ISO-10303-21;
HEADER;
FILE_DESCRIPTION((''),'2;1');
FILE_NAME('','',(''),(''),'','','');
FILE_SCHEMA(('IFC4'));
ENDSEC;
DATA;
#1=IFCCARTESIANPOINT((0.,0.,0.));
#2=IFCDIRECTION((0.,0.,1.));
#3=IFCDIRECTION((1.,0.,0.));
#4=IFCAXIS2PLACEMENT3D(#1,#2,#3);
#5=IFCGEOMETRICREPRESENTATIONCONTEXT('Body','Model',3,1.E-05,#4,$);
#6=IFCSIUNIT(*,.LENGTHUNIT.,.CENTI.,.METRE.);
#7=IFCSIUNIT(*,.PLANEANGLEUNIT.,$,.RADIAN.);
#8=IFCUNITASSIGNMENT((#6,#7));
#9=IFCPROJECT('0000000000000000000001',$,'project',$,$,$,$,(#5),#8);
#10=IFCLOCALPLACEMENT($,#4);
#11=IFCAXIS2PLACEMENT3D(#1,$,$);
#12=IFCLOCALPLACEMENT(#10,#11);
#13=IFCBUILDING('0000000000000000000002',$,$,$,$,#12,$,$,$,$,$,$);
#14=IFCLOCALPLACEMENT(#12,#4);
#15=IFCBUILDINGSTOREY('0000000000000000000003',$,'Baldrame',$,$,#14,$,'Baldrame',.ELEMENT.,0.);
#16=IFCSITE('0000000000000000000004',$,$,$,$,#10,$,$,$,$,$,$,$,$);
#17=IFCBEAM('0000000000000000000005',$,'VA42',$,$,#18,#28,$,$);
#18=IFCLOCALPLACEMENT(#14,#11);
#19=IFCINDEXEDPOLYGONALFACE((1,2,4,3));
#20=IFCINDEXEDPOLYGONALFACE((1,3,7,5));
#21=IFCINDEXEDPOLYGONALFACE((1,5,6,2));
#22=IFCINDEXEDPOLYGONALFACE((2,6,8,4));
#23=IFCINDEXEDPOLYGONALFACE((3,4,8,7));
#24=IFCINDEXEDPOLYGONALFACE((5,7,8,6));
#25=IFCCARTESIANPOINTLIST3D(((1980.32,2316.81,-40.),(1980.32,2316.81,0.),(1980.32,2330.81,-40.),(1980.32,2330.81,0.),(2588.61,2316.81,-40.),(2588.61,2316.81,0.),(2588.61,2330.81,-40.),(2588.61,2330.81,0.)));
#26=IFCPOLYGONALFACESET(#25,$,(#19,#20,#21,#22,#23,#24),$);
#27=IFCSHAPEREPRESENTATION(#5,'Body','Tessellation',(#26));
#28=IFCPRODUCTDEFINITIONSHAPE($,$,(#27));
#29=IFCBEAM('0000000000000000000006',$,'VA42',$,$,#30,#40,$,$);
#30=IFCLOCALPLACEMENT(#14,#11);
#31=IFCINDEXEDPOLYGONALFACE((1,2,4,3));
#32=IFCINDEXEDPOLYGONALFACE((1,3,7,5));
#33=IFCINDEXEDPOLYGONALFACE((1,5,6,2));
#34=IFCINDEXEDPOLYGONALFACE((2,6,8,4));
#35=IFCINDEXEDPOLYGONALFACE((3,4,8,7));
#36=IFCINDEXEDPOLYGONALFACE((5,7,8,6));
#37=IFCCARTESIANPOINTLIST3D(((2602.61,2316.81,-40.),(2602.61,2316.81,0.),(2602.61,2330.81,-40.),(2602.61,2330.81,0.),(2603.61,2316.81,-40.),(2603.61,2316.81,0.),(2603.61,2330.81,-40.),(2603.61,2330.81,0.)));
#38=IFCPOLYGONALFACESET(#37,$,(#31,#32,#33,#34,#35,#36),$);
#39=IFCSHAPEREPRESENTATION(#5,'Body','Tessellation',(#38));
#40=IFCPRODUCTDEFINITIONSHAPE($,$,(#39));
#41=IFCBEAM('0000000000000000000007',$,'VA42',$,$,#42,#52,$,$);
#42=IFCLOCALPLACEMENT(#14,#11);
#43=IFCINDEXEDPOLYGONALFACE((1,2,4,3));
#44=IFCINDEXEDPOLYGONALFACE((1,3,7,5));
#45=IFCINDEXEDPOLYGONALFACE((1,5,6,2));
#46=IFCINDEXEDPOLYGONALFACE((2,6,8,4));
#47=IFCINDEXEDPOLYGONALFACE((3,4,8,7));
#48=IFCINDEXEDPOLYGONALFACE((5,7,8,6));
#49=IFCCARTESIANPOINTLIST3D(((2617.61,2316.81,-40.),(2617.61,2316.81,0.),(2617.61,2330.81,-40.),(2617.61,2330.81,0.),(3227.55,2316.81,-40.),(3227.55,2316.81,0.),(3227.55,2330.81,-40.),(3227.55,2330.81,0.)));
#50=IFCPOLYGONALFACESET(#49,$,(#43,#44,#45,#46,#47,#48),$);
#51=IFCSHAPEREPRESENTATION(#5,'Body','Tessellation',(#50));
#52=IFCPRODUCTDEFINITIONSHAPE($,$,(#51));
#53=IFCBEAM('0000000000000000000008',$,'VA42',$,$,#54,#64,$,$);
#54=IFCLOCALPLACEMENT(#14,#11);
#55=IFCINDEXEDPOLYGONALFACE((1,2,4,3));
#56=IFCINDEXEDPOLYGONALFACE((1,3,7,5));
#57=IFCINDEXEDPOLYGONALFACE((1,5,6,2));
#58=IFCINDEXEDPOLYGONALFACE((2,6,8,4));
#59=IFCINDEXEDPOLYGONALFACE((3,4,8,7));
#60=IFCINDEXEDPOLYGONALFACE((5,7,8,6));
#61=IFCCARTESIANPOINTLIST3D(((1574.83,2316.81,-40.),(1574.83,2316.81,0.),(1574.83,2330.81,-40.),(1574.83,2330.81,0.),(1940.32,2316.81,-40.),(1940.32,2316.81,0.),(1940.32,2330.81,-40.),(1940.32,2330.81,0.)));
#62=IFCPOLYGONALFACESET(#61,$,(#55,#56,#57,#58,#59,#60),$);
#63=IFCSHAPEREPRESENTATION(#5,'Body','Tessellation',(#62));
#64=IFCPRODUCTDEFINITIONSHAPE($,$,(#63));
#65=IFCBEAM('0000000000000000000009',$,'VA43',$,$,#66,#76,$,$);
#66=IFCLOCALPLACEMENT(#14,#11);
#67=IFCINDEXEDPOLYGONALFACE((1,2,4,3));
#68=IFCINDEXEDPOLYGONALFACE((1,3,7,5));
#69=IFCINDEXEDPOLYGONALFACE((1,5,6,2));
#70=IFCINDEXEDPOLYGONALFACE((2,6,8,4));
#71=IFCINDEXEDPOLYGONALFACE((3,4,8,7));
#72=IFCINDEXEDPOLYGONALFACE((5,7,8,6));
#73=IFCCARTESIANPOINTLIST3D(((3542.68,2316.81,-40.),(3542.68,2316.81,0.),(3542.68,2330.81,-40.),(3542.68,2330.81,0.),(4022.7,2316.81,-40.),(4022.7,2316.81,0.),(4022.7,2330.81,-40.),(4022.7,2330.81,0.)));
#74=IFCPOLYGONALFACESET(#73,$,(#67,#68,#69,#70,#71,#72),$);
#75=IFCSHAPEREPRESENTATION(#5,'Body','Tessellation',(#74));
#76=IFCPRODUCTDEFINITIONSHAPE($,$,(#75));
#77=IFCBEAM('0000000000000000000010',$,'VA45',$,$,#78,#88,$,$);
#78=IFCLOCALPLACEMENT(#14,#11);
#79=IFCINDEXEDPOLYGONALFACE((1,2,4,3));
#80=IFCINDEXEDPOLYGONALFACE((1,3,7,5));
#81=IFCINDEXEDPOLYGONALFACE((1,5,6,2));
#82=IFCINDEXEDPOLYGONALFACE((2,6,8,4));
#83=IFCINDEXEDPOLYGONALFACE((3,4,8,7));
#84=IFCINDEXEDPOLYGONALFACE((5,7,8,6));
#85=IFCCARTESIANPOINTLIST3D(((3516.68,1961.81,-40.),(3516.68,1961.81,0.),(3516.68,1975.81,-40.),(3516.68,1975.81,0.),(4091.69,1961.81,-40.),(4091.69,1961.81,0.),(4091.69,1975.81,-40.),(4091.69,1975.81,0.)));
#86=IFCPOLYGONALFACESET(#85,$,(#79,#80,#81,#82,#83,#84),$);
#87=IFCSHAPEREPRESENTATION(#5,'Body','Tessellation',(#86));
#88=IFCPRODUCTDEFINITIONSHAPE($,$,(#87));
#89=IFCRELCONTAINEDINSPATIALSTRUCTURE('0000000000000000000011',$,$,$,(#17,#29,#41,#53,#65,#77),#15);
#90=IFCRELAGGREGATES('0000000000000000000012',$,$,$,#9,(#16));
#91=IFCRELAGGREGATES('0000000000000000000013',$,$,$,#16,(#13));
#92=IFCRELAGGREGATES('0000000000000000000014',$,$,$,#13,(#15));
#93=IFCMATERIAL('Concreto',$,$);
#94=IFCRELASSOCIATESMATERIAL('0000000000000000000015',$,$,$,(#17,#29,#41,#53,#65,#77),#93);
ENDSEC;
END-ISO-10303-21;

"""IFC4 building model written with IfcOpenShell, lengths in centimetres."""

from ifc_helpers import new_model, si_unit, frame, origin, origin_with_axes, origin_2d_with_axis, place, context, project, spatial, rectangle, extrude, material, element, save


model = new_model("IFC4")

# Units and contexts
model_context = context("Model", 3, precision=1e-05, world=origin_with_axes(), identifier="Body")
ifc_project = project(units=[si_unit("LENGTHUNIT", "METRE", prefix="CENTI"), si_unit("PLANEANGLEUNIT", "RADIAN")], contexts=[model_context])

# Site, building, storey
site_placement = place(None, origin_with_axes())
site = spatial("IfcSite", under=ifc_project, at=site_placement)
building_placement = place(site_placement, origin())
building = spatial("IfcBuilding", under=site, at=building_placement)
storey_placement = place(building_placement, origin_with_axes())
storey = spatial("IfcBuildingStorey", under=building, at=storey_placement, Name="Baldrame", LongName="Baldrame", CompositionType="ELEMENT", Elevation=0.0)

# Shared definitions
ifc_material = material(Name="Concreto")

# Beams
beam_1_placement = place(storey_placement, frame((2284.47, 2323.81, 0.0), z_axis=(0.0, 0.0, 1.0), x_axis=(1.0, 0.0, 0.0)))
element("IfcBeam", 1, at=beam_1_placement, inside=storey, material=ifc_material, Name="VA42", context=model_context, shape_type="SolidModel", body=[
    extrude(rectangle(XDim=14.0, YDim=40.0, at=origin_2d_with_axis()), frame((-304.14, 0.0, -20.0), z_axis=(1.0, 0.0, 0.0), x_axis=(0.0, 1.0, 0.0)), (0.0, 0.0, 1.0), 608.29),
])
beam_2_placement = place(storey_placement, frame((2603.11, 2323.81, 0.0), z_axis=(0.0, 0.0, 1.0), x_axis=(1.0, 0.0, 0.0)))
element("IfcBeam", 2, at=beam_2_placement, inside=storey, material=ifc_material, Name="VA42", context=model_context, shape_type="SolidModel", body=[
    extrude(rectangle(XDim=14.0, YDim=40.0, at=origin_2d_with_axis()), frame((-0.5, 0.0, -20.0), z_axis=(1.0, 0.0, 0.0), x_axis=(0.0, 1.0, 0.0)), (0.0, 0.0, 1.0), 1.0),
])
beam_3_placement = place(storey_placement, frame((2922.58, 2323.81, 0.0), z_axis=(0.0, 0.0, 1.0), x_axis=(1.0, 0.0, 0.0)))
element("IfcBeam", 3, at=beam_3_placement, inside=storey, material=ifc_material, Name="VA42", context=model_context, shape_type="SolidModel", body=[
    extrude(rectangle(XDim=14.0, YDim=40.0, at=origin_2d_with_axis()), frame((-304.97, 0.0, -20.0), z_axis=(1.0, 0.0, 0.0), x_axis=(0.0, 1.0, 0.0)), (0.0, 0.0, 1.0), 609.94),
])
beam_4_placement = place(storey_placement, frame((1757.58, 2323.81, 0.0), z_axis=(0.0, 0.0, 1.0), x_axis=(1.0, 0.0, 0.0)))
element("IfcBeam", 4, at=beam_4_placement, inside=storey, material=ifc_material, Name="VA42", context=model_context, shape_type="SolidModel", body=[
    extrude(rectangle(XDim=14.0, YDim=40.0, at=origin_2d_with_axis()), frame((-182.75, 0.0, -20.0), z_axis=(1.0, 0.0, 0.0), x_axis=(0.0, 1.0, 0.0)), (0.0, 0.0, 1.0), 365.49),
])
beam_5_placement = place(storey_placement, frame((3782.69, 2323.81, 0.0), z_axis=(0.0, 0.0, 1.0), x_axis=(1.0, 0.0, 0.0)))
element("IfcBeam", 5, at=beam_5_placement, inside=storey, material=ifc_material, Name="VA43", context=model_context, shape_type="SolidModel", body=[
    extrude(rectangle(XDim=14.0, YDim=40.0, at=origin_2d_with_axis()), frame((-240.01, 0.0, -20.0), z_axis=(1.0, 0.0, 0.0), x_axis=(0.0, 1.0, 0.0)), (0.0, 0.0, 1.0), 480.02),
])
beam_6_placement = place(storey_placement, frame((3804.18, 1968.81, 0.0), z_axis=(0.0, 0.0, 1.0), x_axis=(1.0, 0.0, 0.0)))
element("IfcBeam", 6, at=beam_6_placement, inside=storey, material=ifc_material, Name="VA45", context=model_context, shape_type="SolidModel", body=[
    extrude(rectangle(XDim=14.0, YDim=40.0, at=origin_2d_with_axis()), frame((-287.5, 0.0, -20.0), z_axis=(1.0, 0.0, 0.0), x_axis=(0.0, 1.0, 0.0)), (0.0, 0.0, 1.0), 575.01),
])

save(model, "model.ifc")
